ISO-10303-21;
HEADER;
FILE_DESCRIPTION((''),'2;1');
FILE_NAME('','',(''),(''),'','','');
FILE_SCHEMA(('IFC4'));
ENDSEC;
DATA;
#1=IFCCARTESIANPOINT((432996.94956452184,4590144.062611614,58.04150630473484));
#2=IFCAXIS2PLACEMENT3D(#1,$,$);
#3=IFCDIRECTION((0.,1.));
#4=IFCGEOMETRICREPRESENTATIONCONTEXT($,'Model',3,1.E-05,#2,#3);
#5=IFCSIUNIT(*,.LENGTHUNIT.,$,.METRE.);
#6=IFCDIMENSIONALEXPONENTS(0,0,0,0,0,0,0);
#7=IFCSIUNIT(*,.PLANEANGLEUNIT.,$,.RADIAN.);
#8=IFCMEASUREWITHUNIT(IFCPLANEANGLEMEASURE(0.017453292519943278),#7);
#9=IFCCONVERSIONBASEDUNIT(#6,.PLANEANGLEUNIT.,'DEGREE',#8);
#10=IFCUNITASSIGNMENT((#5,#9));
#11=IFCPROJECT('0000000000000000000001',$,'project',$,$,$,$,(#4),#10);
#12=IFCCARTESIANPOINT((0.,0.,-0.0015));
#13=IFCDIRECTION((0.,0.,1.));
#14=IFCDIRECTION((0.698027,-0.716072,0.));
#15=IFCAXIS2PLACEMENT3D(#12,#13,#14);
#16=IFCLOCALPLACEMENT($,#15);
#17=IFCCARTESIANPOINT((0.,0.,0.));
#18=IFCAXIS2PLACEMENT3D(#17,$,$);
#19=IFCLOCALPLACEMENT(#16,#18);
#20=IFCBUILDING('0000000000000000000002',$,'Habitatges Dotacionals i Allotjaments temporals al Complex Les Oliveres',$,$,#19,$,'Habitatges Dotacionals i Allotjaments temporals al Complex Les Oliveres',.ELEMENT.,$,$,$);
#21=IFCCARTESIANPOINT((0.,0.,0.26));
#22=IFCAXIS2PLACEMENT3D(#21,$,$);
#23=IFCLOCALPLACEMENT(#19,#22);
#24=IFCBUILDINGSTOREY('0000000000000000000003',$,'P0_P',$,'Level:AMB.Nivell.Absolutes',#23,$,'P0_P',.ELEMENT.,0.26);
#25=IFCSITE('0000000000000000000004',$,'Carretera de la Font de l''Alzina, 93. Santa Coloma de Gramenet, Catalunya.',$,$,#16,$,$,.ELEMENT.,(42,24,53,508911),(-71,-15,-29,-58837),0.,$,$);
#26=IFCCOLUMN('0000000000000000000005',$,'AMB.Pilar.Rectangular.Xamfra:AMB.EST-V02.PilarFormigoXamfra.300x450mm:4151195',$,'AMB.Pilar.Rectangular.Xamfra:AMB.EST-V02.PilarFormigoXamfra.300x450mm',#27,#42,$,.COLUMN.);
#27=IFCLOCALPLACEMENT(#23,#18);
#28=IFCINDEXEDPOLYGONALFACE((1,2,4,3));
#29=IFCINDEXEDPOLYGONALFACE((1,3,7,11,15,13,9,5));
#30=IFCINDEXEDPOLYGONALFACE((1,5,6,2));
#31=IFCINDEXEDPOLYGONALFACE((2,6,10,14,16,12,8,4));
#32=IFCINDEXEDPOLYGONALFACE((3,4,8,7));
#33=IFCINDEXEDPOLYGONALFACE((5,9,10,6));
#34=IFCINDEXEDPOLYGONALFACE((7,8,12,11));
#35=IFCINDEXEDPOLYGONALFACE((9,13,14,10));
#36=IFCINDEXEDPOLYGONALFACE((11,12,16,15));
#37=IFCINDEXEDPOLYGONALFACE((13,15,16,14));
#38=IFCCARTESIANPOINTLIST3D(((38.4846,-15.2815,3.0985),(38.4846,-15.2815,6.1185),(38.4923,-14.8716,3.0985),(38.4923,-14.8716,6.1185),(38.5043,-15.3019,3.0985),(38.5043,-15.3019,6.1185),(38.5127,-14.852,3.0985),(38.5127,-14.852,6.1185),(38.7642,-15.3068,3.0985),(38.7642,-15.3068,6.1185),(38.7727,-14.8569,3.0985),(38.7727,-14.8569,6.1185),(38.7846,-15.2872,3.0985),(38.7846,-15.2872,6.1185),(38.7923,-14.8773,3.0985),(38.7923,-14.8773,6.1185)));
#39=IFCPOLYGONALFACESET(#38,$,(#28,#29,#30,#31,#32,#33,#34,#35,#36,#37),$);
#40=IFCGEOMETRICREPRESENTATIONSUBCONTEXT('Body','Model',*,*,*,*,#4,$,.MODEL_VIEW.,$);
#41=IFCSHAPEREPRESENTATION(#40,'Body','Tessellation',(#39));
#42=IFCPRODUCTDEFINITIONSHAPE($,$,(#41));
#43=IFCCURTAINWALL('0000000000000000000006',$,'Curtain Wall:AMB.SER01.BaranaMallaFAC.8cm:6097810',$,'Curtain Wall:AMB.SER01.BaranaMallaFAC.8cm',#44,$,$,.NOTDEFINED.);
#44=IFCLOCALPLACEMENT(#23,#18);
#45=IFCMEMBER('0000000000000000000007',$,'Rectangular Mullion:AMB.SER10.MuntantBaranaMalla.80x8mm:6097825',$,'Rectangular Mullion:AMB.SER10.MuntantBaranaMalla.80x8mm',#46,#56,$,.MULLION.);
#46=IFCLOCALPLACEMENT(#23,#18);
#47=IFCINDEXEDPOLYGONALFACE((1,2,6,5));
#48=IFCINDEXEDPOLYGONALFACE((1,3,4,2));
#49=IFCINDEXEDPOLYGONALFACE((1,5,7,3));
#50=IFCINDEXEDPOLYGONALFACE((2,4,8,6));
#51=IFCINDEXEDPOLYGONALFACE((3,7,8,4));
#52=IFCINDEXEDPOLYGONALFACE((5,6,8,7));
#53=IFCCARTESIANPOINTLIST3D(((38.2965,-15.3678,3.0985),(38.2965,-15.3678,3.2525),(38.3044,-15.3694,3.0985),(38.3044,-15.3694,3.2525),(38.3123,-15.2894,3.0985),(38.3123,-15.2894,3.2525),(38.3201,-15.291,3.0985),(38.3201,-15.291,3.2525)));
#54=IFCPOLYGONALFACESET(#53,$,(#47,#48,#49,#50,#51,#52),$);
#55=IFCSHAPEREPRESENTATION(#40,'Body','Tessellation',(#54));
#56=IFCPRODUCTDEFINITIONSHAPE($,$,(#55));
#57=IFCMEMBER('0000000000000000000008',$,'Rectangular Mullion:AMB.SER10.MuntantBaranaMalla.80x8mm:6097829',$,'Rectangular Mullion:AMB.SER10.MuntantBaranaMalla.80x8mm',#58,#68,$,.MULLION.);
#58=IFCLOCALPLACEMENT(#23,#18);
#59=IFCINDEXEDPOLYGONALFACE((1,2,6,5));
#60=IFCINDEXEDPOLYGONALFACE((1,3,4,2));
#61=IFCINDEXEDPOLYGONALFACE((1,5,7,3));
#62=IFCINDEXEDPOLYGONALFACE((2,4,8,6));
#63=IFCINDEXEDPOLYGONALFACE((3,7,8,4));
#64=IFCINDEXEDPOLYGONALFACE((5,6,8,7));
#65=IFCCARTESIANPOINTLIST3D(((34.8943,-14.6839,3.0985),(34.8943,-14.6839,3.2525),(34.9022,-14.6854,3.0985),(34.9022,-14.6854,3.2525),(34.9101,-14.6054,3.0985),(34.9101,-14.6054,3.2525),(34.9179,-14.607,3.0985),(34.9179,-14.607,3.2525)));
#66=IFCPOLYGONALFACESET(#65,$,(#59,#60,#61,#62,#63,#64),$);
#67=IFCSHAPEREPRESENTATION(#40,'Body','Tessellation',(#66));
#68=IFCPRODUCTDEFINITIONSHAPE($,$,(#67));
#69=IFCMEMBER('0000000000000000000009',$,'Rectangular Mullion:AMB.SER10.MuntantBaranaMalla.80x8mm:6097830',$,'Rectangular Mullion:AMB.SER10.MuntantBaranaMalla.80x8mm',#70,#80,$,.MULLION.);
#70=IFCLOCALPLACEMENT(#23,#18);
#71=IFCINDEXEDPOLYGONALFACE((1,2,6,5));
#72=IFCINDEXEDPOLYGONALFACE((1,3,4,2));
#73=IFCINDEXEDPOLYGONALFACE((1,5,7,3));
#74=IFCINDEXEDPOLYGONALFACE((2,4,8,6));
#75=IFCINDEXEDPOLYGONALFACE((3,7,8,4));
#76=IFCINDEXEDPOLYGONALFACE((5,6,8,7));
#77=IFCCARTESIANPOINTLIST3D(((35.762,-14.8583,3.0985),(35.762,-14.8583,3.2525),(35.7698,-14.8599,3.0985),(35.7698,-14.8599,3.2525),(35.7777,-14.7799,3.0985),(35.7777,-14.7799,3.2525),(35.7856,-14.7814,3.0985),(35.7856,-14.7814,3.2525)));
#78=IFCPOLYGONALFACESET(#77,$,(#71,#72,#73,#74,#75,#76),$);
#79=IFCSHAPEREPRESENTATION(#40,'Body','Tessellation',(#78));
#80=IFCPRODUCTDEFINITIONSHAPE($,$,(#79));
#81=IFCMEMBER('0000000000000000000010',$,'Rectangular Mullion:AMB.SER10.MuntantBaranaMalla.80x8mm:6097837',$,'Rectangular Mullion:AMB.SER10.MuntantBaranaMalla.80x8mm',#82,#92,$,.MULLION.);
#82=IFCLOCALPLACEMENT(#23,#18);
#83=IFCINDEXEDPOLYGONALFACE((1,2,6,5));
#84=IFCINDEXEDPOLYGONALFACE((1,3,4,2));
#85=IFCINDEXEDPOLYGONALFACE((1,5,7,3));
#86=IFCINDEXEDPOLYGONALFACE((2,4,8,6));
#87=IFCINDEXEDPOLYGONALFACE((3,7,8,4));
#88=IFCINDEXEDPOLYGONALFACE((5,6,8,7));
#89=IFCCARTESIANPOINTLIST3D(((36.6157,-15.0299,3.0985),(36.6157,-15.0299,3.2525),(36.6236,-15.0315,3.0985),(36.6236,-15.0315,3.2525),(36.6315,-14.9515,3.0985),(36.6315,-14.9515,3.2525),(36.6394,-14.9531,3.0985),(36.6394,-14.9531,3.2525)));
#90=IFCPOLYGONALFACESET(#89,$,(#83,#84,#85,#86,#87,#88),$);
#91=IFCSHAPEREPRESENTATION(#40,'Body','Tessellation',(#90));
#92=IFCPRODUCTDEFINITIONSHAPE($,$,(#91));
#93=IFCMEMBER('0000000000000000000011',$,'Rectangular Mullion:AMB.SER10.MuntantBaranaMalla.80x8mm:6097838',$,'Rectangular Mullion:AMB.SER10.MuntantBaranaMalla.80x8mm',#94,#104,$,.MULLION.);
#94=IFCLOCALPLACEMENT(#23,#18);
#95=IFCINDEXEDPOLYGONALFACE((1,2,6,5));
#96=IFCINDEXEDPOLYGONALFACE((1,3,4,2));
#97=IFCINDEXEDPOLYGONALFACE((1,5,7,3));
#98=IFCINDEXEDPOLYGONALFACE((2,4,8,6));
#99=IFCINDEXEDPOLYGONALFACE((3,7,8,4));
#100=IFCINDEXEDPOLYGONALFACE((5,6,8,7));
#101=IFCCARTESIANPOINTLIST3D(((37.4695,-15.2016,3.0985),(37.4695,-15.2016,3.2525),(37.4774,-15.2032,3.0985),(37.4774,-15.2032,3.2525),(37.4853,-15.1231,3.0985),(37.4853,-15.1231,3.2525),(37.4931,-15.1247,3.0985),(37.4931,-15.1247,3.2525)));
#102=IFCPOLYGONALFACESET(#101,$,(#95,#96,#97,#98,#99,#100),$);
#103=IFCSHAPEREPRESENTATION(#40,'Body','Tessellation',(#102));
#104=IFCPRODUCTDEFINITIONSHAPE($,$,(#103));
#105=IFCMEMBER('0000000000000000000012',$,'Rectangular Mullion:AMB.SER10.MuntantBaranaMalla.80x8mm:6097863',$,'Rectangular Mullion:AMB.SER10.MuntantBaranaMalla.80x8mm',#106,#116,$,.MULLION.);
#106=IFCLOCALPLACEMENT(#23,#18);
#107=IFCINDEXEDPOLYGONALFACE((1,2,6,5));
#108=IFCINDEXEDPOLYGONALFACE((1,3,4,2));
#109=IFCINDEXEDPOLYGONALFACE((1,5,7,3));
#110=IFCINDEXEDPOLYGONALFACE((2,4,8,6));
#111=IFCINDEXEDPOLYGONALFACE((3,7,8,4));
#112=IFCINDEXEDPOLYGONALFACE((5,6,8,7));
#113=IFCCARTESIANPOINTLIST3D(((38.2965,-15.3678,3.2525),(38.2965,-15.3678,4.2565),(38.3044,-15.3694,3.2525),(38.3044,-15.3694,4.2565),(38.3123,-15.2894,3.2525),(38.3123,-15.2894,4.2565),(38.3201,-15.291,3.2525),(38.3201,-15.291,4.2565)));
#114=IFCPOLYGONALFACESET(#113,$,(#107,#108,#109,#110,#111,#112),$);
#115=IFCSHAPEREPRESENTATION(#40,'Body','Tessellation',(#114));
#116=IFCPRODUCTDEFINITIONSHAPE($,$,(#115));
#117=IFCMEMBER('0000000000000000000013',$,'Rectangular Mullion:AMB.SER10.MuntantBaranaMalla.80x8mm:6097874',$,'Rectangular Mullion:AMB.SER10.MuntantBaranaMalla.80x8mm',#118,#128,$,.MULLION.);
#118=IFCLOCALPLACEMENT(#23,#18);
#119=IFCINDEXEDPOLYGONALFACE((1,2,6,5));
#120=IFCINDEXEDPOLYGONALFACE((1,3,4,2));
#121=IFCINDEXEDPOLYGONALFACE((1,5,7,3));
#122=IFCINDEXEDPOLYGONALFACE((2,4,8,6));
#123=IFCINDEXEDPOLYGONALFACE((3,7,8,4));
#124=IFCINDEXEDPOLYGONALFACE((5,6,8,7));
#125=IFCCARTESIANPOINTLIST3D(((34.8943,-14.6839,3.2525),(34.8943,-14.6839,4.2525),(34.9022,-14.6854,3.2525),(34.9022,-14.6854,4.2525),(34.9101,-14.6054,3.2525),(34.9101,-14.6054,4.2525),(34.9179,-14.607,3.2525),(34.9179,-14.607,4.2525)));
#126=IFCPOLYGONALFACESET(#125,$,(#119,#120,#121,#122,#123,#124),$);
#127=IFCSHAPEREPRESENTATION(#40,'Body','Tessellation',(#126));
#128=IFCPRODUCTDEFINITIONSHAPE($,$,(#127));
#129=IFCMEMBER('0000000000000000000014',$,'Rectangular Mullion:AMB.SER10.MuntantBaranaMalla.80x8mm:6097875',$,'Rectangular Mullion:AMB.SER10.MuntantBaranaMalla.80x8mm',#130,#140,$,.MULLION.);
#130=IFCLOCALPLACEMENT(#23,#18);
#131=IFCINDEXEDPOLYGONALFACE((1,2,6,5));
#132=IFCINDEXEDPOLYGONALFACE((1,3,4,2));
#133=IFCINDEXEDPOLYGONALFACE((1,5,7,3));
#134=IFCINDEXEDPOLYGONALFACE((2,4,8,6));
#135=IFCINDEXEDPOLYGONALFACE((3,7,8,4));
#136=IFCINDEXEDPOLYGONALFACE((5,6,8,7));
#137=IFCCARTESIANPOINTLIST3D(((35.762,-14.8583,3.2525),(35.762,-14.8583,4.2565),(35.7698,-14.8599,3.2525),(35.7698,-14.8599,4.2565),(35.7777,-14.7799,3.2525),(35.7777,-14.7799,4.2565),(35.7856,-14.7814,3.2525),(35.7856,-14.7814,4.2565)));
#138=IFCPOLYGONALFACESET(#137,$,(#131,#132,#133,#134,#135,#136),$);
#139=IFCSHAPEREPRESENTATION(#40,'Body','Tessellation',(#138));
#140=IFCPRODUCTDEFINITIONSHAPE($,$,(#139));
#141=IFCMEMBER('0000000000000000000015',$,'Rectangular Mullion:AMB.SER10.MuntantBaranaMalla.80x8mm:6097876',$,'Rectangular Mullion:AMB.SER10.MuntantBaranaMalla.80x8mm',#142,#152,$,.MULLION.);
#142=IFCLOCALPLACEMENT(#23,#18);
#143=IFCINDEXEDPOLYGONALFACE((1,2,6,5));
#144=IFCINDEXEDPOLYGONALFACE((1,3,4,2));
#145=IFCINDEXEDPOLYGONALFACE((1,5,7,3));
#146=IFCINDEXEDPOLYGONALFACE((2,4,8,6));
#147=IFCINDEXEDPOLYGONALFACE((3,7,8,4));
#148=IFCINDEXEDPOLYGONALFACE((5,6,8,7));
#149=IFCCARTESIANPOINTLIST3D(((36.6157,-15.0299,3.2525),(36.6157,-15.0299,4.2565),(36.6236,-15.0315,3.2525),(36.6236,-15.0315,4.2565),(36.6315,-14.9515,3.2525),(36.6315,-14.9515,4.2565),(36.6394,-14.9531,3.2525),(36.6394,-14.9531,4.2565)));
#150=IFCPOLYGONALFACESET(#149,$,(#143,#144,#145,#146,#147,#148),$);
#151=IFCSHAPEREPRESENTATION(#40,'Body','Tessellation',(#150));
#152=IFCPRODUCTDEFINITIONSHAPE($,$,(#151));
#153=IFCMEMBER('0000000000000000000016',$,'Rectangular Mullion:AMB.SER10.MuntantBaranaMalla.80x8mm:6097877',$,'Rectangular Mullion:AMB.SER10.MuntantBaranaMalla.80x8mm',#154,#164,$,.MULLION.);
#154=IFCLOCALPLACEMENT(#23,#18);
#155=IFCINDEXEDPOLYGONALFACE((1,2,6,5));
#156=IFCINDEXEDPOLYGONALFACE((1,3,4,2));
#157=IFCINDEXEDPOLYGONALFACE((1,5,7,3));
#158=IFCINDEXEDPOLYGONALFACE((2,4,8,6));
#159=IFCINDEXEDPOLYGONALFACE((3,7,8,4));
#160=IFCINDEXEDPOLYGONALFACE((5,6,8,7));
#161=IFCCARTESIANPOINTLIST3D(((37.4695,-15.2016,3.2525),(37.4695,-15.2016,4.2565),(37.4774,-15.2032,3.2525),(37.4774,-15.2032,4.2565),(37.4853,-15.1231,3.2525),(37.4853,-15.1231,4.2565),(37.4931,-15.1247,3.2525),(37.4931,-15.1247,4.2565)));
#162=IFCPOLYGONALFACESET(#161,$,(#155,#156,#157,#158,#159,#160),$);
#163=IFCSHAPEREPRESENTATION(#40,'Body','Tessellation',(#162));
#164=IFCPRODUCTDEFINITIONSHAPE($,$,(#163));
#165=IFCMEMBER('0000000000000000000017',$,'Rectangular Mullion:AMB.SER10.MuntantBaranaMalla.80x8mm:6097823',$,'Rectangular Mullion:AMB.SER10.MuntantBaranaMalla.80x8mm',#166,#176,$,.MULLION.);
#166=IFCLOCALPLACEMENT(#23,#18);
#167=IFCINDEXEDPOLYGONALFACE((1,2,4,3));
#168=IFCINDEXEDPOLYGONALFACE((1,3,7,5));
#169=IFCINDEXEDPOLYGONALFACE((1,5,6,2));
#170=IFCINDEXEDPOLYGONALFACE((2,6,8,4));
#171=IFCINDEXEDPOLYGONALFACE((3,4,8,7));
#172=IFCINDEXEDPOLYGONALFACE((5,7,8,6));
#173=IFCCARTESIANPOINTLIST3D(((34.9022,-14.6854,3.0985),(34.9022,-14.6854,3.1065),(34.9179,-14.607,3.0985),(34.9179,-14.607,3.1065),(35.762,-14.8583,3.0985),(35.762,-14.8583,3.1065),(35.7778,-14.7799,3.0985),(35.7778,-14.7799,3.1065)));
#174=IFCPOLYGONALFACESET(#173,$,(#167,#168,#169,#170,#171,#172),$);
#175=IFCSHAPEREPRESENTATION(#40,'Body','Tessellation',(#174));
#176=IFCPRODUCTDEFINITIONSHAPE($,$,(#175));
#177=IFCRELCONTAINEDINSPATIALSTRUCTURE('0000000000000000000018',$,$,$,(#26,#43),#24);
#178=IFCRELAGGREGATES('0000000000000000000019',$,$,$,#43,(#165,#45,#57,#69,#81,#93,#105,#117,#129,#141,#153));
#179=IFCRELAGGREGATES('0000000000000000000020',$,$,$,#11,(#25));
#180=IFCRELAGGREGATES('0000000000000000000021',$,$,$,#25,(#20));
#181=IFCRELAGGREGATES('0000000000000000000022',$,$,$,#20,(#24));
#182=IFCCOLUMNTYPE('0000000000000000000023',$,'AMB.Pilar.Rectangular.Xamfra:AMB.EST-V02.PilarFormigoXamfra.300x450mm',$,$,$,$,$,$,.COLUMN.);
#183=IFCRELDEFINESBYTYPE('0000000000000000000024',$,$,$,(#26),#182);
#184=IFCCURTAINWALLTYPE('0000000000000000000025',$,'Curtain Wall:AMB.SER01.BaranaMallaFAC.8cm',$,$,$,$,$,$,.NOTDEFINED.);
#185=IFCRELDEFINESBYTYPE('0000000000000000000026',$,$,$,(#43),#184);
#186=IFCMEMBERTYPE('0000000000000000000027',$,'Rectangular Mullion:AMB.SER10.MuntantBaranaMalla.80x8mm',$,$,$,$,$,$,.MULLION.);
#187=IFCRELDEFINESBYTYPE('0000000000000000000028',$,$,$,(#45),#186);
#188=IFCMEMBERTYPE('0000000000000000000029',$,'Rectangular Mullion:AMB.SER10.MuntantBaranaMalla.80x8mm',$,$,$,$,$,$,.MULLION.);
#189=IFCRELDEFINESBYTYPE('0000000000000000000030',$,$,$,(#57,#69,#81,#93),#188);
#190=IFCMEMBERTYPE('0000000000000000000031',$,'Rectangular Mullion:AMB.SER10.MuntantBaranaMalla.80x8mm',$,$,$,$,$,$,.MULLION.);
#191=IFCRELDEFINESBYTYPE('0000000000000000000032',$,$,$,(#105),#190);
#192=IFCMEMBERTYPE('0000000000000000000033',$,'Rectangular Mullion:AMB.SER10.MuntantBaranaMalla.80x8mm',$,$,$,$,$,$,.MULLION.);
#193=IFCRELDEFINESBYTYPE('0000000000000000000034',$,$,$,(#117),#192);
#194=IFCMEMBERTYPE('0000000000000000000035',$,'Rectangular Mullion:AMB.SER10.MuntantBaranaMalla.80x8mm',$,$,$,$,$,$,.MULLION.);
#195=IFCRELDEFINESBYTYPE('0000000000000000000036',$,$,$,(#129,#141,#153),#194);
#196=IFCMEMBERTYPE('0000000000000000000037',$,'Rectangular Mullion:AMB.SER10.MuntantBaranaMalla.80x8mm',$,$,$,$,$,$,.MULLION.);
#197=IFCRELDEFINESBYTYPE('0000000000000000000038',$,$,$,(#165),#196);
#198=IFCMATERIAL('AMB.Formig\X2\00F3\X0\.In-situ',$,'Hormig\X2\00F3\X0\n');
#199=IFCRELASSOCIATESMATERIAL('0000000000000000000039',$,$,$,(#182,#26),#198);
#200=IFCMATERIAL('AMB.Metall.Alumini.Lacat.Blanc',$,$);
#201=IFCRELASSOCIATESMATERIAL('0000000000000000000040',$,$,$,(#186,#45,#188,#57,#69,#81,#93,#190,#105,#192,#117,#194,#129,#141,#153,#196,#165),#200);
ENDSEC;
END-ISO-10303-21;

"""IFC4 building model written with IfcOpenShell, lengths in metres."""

from ifc_helpers import new_model, entity, si_unit, converted_unit, direction, frame, origin, place, context, subcontext, project, spatial, indexed_curve, outline, extrude, source, transform, mapped, material, type_object, type_shapes, element, aggregate, save


model = new_model("IFC4")

# Units and contexts
model_context = context("Model", 3, precision=1e-05, world=frame((432996.94956452184, 4590144.062611614, 58.04150630473484)), true_north=direction((0.0, 1.0)))
body_context = subcontext(model_context, "Body", "Model", "MODEL_VIEW")
ifc_project = project(units=[si_unit("LENGTHUNIT", "METRE"), converted_unit("PLANEANGLEUNIT", "DEGREE", entity("IfcPlaneAngleMeasure", 0.017453292519943278), si_unit("PLANEANGLEUNIT", "RADIAN"), dimensions=[0, 0, 0, 0, 0, 0, 0])], contexts=[model_context])

# Site, building, storey
site_placement = place(None, frame((0.0, 0.0, -0.0015), z_axis=(0.0, 0.0, 1.0), x_axis=(0.698027, -0.716072, 0.0)))
site = spatial("IfcSite", under=ifc_project, at=site_placement, Name="Carretera de la Font de l'Alzina, 93. Santa Coloma de Gramenet, Catalunya.", CompositionType="ELEMENT", RefLatitude=(42, 24, 53, 508911), RefLongitude=(-71, -15, -29, -58837), RefElevation=0.0)
building_placement = place(site_placement, origin())
building = spatial("IfcBuilding", under=site, at=building_placement, Name="Habitatges Dotacionals i Allotjaments temporals al Complex Les Oliveres", LongName="Habitatges Dotacionals i Allotjaments temporals al Complex Les Oliveres", CompositionType="ELEMENT")
storey_placement = place(building_placement, frame((0.0, 0.0, 0.26)))
storey = spatial("IfcBuildingStorey", under=building, at=storey_placement, Name="P0_P", ObjectType="Level:AMB.Nivell.Absolutes", LongName="P0_P", CompositionType="ELEMENT", Elevation=0.26)

# Column
ifc_material_1 = material(Name="AMB.Formigó.In-situ", Category="Hormigón")
column_type = type_object("IfcColumnType", Name="AMB.Pilar.Rectangular.Xamfra:AMB.EST-V02.PilarFormigoXamfra.300x450mm", PredefinedType="COLUMN", material=ifc_material_1)
shared_shape_1 = source(origin(), body_context, "Body", "SweptSolid", [
    extrude(outline(indexed_curve([(-0.13, -0.225), (0.13, -0.225), (0.15, -0.205), (0.15, 0.205), (0.13, 0.225), (-0.13, 0.225), (-0.15, 0.205), (-0.15, -0.205), (-0.13, -0.225)], self_intersect=False)), frame((0.0, 0.0, 3.3585), z_axis=(0.0, 0.0, 1.0), x_axis=(-1.0, 0.0, 0.0)), (0.0, 0.0, 1.0), 3.02),
])
type_shapes(column_type, [shared_shape_1])
column_placement = place(storey_placement, frame((38.6385, -15.0794, -0.26), z_axis=(0.0, 0.0, 1.0), x_axis=(0.999823, -0.018804, 0.0)))
element("IfcColumn", 1, at=column_placement, inside=storey, type_object=column_type, material=ifc_material_1, Name="AMB.Pilar.Rectangular.Xamfra:AMB.EST-V02.PilarFormigoXamfra.300x450mm:4151195", ObjectType="AMB.Pilar.Rectangular.Xamfra:AMB.EST-V02.PilarFormigoXamfra.300x450mm", PredefinedType="COLUMN", context=body_context, shape_type="MappedRepresentation", body=[
    mapped(shared_shape_1, transform((0.0, 0.0, 0.0), scale=1.0)),
])

# Curtain wall, members
curtain_wall_type = type_object("IfcCurtainWallType", Name="Curtain Wall:AMB.SER01.BaranaMallaFAC.8cm", PredefinedType="NOTDEFINED")
curtain_wall_placement = place(storey_placement, frame((0.0, 0.0, -0.26)))
curtain_wall = element("IfcCurtainWall", 2, at=curtain_wall_placement, inside=storey, type_object=curtain_wall_type, Name="Curtain Wall:AMB.SER01.BaranaMallaFAC.8cm:6097810", ObjectType="Curtain Wall:AMB.SER01.BaranaMallaFAC.8cm", PredefinedType="NOTDEFINED")
ifc_material_2 = material(Name="AMB.Metall.Alumini.Lacat.Blanc")
member_type_1 = type_object("IfcMemberType", Name="Rectangular Mullion:AMB.SER10.MuntantBaranaMalla.80x8mm", PredefinedType="MULLION", material=ifc_material_2)
shared_shape_2 = source(origin(), body_context, "Body", "SweptSolid", [
    extrude(outline(indexed_curve([(-0.004, -0.04), (0.004, -0.04), (0.004, 0.04), (-0.004, 0.04), (-0.004, -0.04)], self_intersect=False)), frame((-0.004, -0.04, -0.154), z_axis=(0.0, 0.0, 1.0), x_axis=(-1.0, 0.0, 0.0)), (0.0, 0.0, 1.0), 0.154),
])
type_shapes(member_type_1, [shared_shape_2])
member_1_placement = place(curtain_wall_placement, frame((38.3044, -15.3694, 3.3585), z_axis=(0.0, 0.0, -1.0), x_axis=(0.980384, -0.197097, 0.0)))
member_1 = element("IfcMember", 3, at=member_1_placement, type_object=member_type_1, material=ifc_material_2, Name="Rectangular Mullion:AMB.SER10.MuntantBaranaMalla.80x8mm:6097825", ObjectType="Rectangular Mullion:AMB.SER10.MuntantBaranaMalla.80x8mm", PredefinedType="MULLION", context=body_context, shape_type="MappedRepresentation", body=[
    mapped(shared_shape_2, transform((0.0, 0.0, 0.0), scale=1.0)),
])
member_type_2 = type_object("IfcMemberType", Name="Rectangular Mullion:AMB.SER10.MuntantBaranaMalla.80x8mm", PredefinedType="MULLION", material=ifc_material_2)
shared_shape_3 = source(origin(), body_context, "Body", "SweptSolid", [
    extrude(outline(indexed_curve([(-0.004, -0.04), (0.004, -0.04), (0.004, 0.04), (-0.004, 0.04), (-0.004, -0.04)], self_intersect=False)), frame((0.0, -0.04, -0.154), z_axis=(0.0, 0.0, 1.0), x_axis=(-1.0, 0.0, 0.0)), (0.0, 0.0, 1.0), 0.154),
])
type_shapes(member_type_2, [shared_shape_3])
member_2_placement = place(curtain_wall_placement, frame((34.8982, -14.6846, 3.3585), z_axis=(0.0, 0.0, -1.0), x_axis=(0.980384, -0.197097, 0.0)))
member_2 = element("IfcMember", 4, at=member_2_placement, type_object=member_type_2, material=ifc_material_2, Name="Rectangular Mullion:AMB.SER10.MuntantBaranaMalla.80x8mm:6097829", ObjectType="Rectangular Mullion:AMB.SER10.MuntantBaranaMalla.80x8mm", PredefinedType="MULLION", context=body_context, shape_type="MappedRepresentation", body=[
    mapped(shared_shape_3, transform((0.0, 0.0, 0.0), scale=1.0)),
])
member_3_placement = place(curtain_wall_placement, frame((35.7659, -14.8591, 3.3585), z_axis=(0.0, 0.0, -1.0), x_axis=(0.980384, -0.197097, 0.0)))
member_3 = element("IfcMember", 5, at=member_3_placement, type_object=member_type_2, material=ifc_material_2, Name="Rectangular Mullion:AMB.SER10.MuntantBaranaMalla.80x8mm:6097830", ObjectType="Rectangular Mullion:AMB.SER10.MuntantBaranaMalla.80x8mm", PredefinedType="MULLION", context=body_context, shape_type="MappedRepresentation", body=[
    mapped(shared_shape_3, transform((0.0, 0.0, 0.0), scale=1.0)),
])
member_4_placement = place(curtain_wall_placement, frame((36.6197, -15.0307, 3.3585), z_axis=(0.0, 0.0, -1.0), x_axis=(0.980384, -0.197097, 0.0)))
member_4 = element("IfcMember", 6, at=member_4_placement, type_object=member_type_2, material=ifc_material_2, Name="Rectangular Mullion:AMB.SER10.MuntantBaranaMalla.80x8mm:6097837", ObjectType="Rectangular Mullion:AMB.SER10.MuntantBaranaMalla.80x8mm", PredefinedType="MULLION", context=body_context, shape_type="MappedRepresentation", body=[
    mapped(shared_shape_3, transform((0.0, 0.0, 0.0), scale=1.0)),
])
member_5_placement = place(curtain_wall_placement, frame((37.4734, -15.2024, 3.3585), z_axis=(0.0, 0.0, -1.0), x_axis=(0.980384, -0.197097, 0.0)))
member_5 = element("IfcMember", 7, at=member_5_placement, type_object=member_type_2, material=ifc_material_2, Name="Rectangular Mullion:AMB.SER10.MuntantBaranaMalla.80x8mm:6097838", ObjectType="Rectangular Mullion:AMB.SER10.MuntantBaranaMalla.80x8mm", PredefinedType="MULLION", context=body_context, shape_type="MappedRepresentation", body=[
    mapped(shared_shape_3, transform((0.0, 0.0, 0.0), scale=1.0)),
])
member_type_3 = type_object("IfcMemberType", Name="Rectangular Mullion:AMB.SER10.MuntantBaranaMalla.80x8mm", PredefinedType="MULLION", material=ifc_material_2)
shared_shape_4 = source(origin(), body_context, "Body", "SweptSolid", [
    extrude(outline(indexed_curve([(-0.004, -0.04), (0.004, -0.04), (0.004, 0.04), (-0.004, 0.04), (-0.004, -0.04)], self_intersect=False)), frame((-0.004, -0.04, -1.004), z_axis=(0.0, 0.0, 1.0), x_axis=(-1.0, 0.0, 0.0)), (0.0, 0.0, 1.0), 1.004),
])
type_shapes(member_type_3, [shared_shape_4])
member_6_placement = place(curtain_wall_placement, frame((38.3044, -15.3694, 3.5125), z_axis=(0.0, 0.0, -1.0), x_axis=(0.980384, -0.197097, 0.0)))
member_6 = element("IfcMember", 8, at=member_6_placement, type_object=member_type_3, material=ifc_material_2, Name="Rectangular Mullion:AMB.SER10.MuntantBaranaMalla.80x8mm:6097863", ObjectType="Rectangular Mullion:AMB.SER10.MuntantBaranaMalla.80x8mm", PredefinedType="MULLION", context=body_context, shape_type="MappedRepresentation", body=[
    mapped(shared_shape_4, transform((0.0, 0.0, 0.0), scale=1.0)),
])
member_type_4 = type_object("IfcMemberType", Name="Rectangular Mullion:AMB.SER10.MuntantBaranaMalla.80x8mm", PredefinedType="MULLION", material=ifc_material_2)
shared_shape_5 = source(origin(), body_context, "Body", "SweptSolid", [
    extrude(outline(indexed_curve([(-0.004, -0.04), (0.004, -0.04), (0.004, 0.04), (-0.004, 0.04), (-0.004, -0.04)], self_intersect=False)), frame((0.0, -0.04, -1.0), z_axis=(0.0, 0.0, 1.0), x_axis=(-1.0, 0.0, 0.0)), (0.0, 0.0, 1.0), 1.0),
])
type_shapes(member_type_4, [shared_shape_5])
member_7_placement = place(curtain_wall_placement, frame((34.8982, -14.6846, 3.5125), z_axis=(0.0, 0.0, -1.0), x_axis=(0.980384, -0.197097, 0.0)))
member_7 = element("IfcMember", 9, at=member_7_placement, type_object=member_type_4, material=ifc_material_2, Name="Rectangular Mullion:AMB.SER10.MuntantBaranaMalla.80x8mm:6097874", ObjectType="Rectangular Mullion:AMB.SER10.MuntantBaranaMalla.80x8mm", PredefinedType="MULLION", context=body_context, shape_type="MappedRepresentation", body=[
    mapped(shared_shape_5, transform((0.0, 0.0, 0.0), scale=1.0)),
])
member_type_5 = type_object("IfcMemberType", Name="Rectangular Mullion:AMB.SER10.MuntantBaranaMalla.80x8mm", PredefinedType="MULLION", material=ifc_material_2)
shared_shape_6 = source(origin(), body_context, "Body", "SweptSolid", [
    extrude(outline(indexed_curve([(-0.004, -0.04), (0.004, -0.04), (0.004, 0.04), (-0.004, 0.04), (-0.004, -0.04)], self_intersect=False)), frame((0.0, -0.04, -1.004), z_axis=(0.0, 0.0, 1.0), x_axis=(-1.0, 0.0, 0.0)), (0.0, 0.0, 1.0), 1.004),
])
type_shapes(member_type_5, [shared_shape_6])
member_8_placement = place(curtain_wall_placement, frame((35.7659, -14.8591, 3.5125), z_axis=(0.0, 0.0, -1.0), x_axis=(0.980384, -0.197097, 0.0)))
member_8 = element("IfcMember", 10, at=member_8_placement, type_object=member_type_5, material=ifc_material_2, Name="Rectangular Mullion:AMB.SER10.MuntantBaranaMalla.80x8mm:6097875", ObjectType="Rectangular Mullion:AMB.SER10.MuntantBaranaMalla.80x8mm", PredefinedType="MULLION", context=body_context, shape_type="MappedRepresentation", body=[
    mapped(shared_shape_6, transform((0.0, 0.0, 0.0), scale=1.0)),
])
member_9_placement = place(curtain_wall_placement, frame((36.6197, -15.0307, 3.5125), z_axis=(0.0, 0.0, -1.0), x_axis=(0.980384, -0.197097, 0.0)))
member_9 = element("IfcMember", 11, at=member_9_placement, type_object=member_type_5, material=ifc_material_2, Name="Rectangular Mullion:AMB.SER10.MuntantBaranaMalla.80x8mm:6097876", ObjectType="Rectangular Mullion:AMB.SER10.MuntantBaranaMalla.80x8mm", PredefinedType="MULLION", context=body_context, shape_type="MappedRepresentation", body=[
    mapped(shared_shape_6, transform((0.0, 0.0, 0.0), scale=1.0)),
])
member_10_placement = place(curtain_wall_placement, frame((37.4734, -15.2024, 3.5125), z_axis=(0.0, 0.0, -1.0), x_axis=(0.980384, -0.197097, 0.0)))
member_10 = element("IfcMember", 12, at=member_10_placement, type_object=member_type_5, material=ifc_material_2, Name="Rectangular Mullion:AMB.SER10.MuntantBaranaMalla.80x8mm:6097877", ObjectType="Rectangular Mullion:AMB.SER10.MuntantBaranaMalla.80x8mm", PredefinedType="MULLION", context=body_context, shape_type="MappedRepresentation", body=[
    mapped(shared_shape_6, transform((0.0, 0.0, 0.0), scale=1.0)),
])
member_type_6 = type_object("IfcMemberType", Name="Rectangular Mullion:AMB.SER10.MuntantBaranaMalla.80x8mm", PredefinedType="MULLION", material=ifc_material_2)
shared_shape_7 = source(origin(), body_context, "Body", "SweptSolid", [
    extrude(outline(indexed_curve([(-0.004, -0.04), (0.004, -0.04), (0.004, 0.04), (-0.004, 0.04), (-0.004, -0.04)], self_intersect=False)), frame((-0.004, -0.04, -0.8771), z_axis=(0.0, 0.0, 1.0), x_axis=(-1.0, 0.0, 0.0)), (0.0, 0.0, 1.0), 0.8771),
])
type_shapes(member_type_6, [shared_shape_7])
member_11_placement = place(curtain_wall_placement, frame((34.9022, -14.6854, 3.3585), z_axis=(-0.980384, 0.197097, 0.0), x_axis=(0.0, 0.0, -1.0)))
member_11 = element("IfcMember", 13, at=member_11_placement, type_object=member_type_6, material=ifc_material_2, Name="Rectangular Mullion:AMB.SER10.MuntantBaranaMalla.80x8mm:6097823", ObjectType="Rectangular Mullion:AMB.SER10.MuntantBaranaMalla.80x8mm", PredefinedType="MULLION", context=body_context, shape_type="MappedRepresentation", body=[
    mapped(shared_shape_7, transform((0.0, 0.0, 0.0), scale=1.0)),
])
aggregate(curtain_wall, [member_11, member_1, member_2, member_3, member_4, member_5, member_6, member_7, member_8, member_9, member_10])

save(model, "model.ifc")
